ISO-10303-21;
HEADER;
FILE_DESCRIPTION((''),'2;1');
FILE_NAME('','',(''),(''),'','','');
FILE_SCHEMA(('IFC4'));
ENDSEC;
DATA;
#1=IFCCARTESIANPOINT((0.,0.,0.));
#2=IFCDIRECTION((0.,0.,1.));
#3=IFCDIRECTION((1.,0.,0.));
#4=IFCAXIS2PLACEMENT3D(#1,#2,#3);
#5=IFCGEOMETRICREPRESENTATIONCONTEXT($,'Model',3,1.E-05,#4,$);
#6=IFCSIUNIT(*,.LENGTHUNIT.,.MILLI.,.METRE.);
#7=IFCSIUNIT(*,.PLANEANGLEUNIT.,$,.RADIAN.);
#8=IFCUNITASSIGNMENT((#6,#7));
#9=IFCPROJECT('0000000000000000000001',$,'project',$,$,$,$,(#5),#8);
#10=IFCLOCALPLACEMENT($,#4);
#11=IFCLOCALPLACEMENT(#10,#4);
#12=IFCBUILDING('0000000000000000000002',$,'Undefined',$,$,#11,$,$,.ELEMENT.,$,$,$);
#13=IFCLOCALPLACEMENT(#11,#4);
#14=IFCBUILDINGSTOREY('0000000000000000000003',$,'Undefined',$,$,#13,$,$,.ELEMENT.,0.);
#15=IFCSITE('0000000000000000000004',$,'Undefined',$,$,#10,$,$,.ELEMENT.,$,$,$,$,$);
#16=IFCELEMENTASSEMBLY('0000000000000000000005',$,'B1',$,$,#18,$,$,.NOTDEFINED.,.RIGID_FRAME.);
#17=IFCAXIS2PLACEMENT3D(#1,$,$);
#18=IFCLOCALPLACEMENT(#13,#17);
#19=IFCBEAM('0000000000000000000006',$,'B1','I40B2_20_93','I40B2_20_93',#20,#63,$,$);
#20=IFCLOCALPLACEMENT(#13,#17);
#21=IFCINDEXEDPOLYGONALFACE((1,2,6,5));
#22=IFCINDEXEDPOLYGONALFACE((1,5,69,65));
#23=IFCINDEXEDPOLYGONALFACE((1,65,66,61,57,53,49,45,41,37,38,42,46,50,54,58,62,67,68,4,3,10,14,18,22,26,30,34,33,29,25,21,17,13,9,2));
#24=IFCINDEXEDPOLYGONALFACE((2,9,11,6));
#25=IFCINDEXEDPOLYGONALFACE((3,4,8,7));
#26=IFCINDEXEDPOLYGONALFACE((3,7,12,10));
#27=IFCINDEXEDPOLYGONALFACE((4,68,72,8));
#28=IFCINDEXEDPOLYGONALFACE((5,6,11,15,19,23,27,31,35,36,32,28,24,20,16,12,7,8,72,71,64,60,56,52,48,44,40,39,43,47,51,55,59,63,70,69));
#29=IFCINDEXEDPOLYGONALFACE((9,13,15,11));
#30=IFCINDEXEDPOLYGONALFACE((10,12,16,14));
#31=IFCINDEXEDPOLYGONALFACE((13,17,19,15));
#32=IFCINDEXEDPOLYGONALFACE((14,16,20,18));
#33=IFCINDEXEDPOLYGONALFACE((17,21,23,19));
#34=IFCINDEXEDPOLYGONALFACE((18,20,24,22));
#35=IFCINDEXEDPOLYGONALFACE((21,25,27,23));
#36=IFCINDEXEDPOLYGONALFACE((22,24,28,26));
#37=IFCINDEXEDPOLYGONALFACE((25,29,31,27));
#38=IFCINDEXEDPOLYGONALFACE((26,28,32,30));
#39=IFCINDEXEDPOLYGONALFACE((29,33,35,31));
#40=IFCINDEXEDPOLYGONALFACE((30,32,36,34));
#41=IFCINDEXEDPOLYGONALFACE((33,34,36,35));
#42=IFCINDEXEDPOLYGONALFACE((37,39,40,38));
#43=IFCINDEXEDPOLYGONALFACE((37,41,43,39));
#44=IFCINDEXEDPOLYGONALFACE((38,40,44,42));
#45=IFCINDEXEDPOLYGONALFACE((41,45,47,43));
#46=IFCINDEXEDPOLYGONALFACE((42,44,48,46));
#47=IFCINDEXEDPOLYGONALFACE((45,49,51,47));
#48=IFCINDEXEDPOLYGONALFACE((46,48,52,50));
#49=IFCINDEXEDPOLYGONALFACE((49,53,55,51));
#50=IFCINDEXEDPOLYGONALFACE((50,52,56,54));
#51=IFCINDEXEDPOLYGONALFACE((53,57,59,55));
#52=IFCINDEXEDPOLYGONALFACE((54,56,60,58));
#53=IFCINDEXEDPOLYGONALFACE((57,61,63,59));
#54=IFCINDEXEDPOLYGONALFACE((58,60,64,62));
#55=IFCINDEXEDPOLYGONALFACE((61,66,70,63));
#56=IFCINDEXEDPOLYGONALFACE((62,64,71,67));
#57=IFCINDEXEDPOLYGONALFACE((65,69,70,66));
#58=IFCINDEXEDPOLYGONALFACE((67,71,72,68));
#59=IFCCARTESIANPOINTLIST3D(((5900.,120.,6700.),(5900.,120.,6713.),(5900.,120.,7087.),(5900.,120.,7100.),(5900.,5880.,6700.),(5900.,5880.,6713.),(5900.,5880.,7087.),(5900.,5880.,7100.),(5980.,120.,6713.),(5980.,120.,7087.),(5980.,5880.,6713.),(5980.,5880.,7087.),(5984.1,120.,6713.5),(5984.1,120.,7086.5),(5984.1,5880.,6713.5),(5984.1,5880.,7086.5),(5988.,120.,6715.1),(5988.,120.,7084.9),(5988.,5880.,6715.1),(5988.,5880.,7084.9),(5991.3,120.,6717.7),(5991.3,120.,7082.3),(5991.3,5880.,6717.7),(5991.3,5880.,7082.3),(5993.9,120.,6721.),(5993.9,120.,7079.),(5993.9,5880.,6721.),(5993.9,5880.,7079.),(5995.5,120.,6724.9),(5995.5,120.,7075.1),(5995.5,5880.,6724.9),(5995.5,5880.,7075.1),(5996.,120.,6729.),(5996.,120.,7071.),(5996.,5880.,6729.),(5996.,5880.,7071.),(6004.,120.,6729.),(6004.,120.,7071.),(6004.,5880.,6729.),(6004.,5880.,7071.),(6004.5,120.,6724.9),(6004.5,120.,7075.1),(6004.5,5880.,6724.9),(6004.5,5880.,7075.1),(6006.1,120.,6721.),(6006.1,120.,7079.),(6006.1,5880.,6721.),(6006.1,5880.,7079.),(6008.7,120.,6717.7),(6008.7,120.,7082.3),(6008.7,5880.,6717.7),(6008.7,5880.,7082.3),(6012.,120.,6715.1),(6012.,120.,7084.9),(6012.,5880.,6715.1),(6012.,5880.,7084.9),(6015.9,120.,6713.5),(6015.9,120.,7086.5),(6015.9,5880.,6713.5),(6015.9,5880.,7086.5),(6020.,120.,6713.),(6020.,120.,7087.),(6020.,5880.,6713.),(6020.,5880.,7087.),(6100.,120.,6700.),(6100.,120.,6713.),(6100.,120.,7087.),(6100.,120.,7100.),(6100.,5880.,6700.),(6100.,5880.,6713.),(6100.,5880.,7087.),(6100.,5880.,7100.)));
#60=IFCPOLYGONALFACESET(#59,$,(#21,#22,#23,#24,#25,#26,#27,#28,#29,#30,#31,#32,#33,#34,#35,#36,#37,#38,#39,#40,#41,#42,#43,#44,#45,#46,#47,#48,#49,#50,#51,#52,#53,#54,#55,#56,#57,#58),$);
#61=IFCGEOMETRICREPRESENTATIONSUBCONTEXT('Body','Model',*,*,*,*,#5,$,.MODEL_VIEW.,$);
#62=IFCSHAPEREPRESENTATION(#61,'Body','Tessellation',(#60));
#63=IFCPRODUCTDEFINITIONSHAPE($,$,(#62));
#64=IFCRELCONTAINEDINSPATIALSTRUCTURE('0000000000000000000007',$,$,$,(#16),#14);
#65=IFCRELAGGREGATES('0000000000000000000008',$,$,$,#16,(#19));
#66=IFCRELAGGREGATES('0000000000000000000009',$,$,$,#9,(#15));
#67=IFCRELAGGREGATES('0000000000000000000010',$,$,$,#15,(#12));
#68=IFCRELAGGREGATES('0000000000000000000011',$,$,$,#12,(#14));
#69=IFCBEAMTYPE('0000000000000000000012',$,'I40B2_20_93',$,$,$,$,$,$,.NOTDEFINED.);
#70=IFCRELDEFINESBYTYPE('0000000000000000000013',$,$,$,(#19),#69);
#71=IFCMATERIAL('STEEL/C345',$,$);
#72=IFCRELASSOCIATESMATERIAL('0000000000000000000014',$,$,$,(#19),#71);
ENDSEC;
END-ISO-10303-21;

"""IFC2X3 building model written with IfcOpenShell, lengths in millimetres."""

from ifc_helpers import new_model, si_unit, frame, origin_with_axes, origin_2d_with_axis, place, context, subcontext, project, spatial, i_section, extrude, material, type_object, element, aggregate, save


model = new_model("IFC2X3")

# Units and contexts
model_context = context("Model", 3, precision=1e-05, world=origin_with_axes())
body_context = subcontext(model_context, "Body", "Model", "MODEL_VIEW")
ifc_project = project(units=[si_unit("LENGTHUNIT", "METRE", prefix="MILLI"), si_unit("PLANEANGLEUNIT", "RADIAN")], contexts=[model_context])

# Site, building, storey
site_placement = place(None, origin_with_axes())
site = spatial("IfcSite", under=ifc_project, at=site_placement, Name="Undefined", CompositionType="ELEMENT")
building_placement = place(site_placement, origin_with_axes())
building = spatial("IfcBuilding", under=site, at=building_placement, Name="Undefined", CompositionType="ELEMENT")
storey_placement = place(building_placement, origin_with_axes())
storey = spatial("IfcBuildingStorey", under=building, at=storey_placement, Name="Undefined", CompositionType="ELEMENT", Elevation=0.0)

# Element assembly, beam
ifc_material_1 = material(Name="STEEL/C345")
beam_type_1 = type_object("IfcBeamType", Name="I40B2_20_93", PredefinedType="NOTDEFINED")
assembly_1_placement = place(storey_placement, origin_with_axes())
assembly_1 = element("IfcElementAssembly", 1, at=assembly_1_placement, inside=storey, Name="B1", AssemblyPlace="NOTDEFINED", PredefinedType="RIGID_FRAME")
beam_1_placement = place(assembly_1_placement, frame((6000.0, 120.0, 6900.0), z_axis=(0.0, 0.0, 1.0), x_axis=(0.0, 1.0, 0.0)))
beam_1 = element("IfcBeam", 2, at=beam_1_placement, type_object=beam_type_1, material=ifc_material_1, Name="B1", Description="I40B2_20_93", ObjectType="I40B2_20_93", context=body_context, shape_type="SweptSolid", body=[
    extrude(i_section(OverallWidth=200.0, OverallDepth=400.0, WebThickness=8.0, FlangeThickness=13.0, FilletRadius=16.0, at=origin_2d_with_axis()), frame((5760.0, 0.0, 0.0), z_axis=(-1.0, 0.0, 0.0), x_axis=(0.0, -1.0, 0.0)), (0.0, 0.0, 1.0), 5760.0),
])
aggregate(assembly_1, [beam_1])

save(model, "model.ifc")
